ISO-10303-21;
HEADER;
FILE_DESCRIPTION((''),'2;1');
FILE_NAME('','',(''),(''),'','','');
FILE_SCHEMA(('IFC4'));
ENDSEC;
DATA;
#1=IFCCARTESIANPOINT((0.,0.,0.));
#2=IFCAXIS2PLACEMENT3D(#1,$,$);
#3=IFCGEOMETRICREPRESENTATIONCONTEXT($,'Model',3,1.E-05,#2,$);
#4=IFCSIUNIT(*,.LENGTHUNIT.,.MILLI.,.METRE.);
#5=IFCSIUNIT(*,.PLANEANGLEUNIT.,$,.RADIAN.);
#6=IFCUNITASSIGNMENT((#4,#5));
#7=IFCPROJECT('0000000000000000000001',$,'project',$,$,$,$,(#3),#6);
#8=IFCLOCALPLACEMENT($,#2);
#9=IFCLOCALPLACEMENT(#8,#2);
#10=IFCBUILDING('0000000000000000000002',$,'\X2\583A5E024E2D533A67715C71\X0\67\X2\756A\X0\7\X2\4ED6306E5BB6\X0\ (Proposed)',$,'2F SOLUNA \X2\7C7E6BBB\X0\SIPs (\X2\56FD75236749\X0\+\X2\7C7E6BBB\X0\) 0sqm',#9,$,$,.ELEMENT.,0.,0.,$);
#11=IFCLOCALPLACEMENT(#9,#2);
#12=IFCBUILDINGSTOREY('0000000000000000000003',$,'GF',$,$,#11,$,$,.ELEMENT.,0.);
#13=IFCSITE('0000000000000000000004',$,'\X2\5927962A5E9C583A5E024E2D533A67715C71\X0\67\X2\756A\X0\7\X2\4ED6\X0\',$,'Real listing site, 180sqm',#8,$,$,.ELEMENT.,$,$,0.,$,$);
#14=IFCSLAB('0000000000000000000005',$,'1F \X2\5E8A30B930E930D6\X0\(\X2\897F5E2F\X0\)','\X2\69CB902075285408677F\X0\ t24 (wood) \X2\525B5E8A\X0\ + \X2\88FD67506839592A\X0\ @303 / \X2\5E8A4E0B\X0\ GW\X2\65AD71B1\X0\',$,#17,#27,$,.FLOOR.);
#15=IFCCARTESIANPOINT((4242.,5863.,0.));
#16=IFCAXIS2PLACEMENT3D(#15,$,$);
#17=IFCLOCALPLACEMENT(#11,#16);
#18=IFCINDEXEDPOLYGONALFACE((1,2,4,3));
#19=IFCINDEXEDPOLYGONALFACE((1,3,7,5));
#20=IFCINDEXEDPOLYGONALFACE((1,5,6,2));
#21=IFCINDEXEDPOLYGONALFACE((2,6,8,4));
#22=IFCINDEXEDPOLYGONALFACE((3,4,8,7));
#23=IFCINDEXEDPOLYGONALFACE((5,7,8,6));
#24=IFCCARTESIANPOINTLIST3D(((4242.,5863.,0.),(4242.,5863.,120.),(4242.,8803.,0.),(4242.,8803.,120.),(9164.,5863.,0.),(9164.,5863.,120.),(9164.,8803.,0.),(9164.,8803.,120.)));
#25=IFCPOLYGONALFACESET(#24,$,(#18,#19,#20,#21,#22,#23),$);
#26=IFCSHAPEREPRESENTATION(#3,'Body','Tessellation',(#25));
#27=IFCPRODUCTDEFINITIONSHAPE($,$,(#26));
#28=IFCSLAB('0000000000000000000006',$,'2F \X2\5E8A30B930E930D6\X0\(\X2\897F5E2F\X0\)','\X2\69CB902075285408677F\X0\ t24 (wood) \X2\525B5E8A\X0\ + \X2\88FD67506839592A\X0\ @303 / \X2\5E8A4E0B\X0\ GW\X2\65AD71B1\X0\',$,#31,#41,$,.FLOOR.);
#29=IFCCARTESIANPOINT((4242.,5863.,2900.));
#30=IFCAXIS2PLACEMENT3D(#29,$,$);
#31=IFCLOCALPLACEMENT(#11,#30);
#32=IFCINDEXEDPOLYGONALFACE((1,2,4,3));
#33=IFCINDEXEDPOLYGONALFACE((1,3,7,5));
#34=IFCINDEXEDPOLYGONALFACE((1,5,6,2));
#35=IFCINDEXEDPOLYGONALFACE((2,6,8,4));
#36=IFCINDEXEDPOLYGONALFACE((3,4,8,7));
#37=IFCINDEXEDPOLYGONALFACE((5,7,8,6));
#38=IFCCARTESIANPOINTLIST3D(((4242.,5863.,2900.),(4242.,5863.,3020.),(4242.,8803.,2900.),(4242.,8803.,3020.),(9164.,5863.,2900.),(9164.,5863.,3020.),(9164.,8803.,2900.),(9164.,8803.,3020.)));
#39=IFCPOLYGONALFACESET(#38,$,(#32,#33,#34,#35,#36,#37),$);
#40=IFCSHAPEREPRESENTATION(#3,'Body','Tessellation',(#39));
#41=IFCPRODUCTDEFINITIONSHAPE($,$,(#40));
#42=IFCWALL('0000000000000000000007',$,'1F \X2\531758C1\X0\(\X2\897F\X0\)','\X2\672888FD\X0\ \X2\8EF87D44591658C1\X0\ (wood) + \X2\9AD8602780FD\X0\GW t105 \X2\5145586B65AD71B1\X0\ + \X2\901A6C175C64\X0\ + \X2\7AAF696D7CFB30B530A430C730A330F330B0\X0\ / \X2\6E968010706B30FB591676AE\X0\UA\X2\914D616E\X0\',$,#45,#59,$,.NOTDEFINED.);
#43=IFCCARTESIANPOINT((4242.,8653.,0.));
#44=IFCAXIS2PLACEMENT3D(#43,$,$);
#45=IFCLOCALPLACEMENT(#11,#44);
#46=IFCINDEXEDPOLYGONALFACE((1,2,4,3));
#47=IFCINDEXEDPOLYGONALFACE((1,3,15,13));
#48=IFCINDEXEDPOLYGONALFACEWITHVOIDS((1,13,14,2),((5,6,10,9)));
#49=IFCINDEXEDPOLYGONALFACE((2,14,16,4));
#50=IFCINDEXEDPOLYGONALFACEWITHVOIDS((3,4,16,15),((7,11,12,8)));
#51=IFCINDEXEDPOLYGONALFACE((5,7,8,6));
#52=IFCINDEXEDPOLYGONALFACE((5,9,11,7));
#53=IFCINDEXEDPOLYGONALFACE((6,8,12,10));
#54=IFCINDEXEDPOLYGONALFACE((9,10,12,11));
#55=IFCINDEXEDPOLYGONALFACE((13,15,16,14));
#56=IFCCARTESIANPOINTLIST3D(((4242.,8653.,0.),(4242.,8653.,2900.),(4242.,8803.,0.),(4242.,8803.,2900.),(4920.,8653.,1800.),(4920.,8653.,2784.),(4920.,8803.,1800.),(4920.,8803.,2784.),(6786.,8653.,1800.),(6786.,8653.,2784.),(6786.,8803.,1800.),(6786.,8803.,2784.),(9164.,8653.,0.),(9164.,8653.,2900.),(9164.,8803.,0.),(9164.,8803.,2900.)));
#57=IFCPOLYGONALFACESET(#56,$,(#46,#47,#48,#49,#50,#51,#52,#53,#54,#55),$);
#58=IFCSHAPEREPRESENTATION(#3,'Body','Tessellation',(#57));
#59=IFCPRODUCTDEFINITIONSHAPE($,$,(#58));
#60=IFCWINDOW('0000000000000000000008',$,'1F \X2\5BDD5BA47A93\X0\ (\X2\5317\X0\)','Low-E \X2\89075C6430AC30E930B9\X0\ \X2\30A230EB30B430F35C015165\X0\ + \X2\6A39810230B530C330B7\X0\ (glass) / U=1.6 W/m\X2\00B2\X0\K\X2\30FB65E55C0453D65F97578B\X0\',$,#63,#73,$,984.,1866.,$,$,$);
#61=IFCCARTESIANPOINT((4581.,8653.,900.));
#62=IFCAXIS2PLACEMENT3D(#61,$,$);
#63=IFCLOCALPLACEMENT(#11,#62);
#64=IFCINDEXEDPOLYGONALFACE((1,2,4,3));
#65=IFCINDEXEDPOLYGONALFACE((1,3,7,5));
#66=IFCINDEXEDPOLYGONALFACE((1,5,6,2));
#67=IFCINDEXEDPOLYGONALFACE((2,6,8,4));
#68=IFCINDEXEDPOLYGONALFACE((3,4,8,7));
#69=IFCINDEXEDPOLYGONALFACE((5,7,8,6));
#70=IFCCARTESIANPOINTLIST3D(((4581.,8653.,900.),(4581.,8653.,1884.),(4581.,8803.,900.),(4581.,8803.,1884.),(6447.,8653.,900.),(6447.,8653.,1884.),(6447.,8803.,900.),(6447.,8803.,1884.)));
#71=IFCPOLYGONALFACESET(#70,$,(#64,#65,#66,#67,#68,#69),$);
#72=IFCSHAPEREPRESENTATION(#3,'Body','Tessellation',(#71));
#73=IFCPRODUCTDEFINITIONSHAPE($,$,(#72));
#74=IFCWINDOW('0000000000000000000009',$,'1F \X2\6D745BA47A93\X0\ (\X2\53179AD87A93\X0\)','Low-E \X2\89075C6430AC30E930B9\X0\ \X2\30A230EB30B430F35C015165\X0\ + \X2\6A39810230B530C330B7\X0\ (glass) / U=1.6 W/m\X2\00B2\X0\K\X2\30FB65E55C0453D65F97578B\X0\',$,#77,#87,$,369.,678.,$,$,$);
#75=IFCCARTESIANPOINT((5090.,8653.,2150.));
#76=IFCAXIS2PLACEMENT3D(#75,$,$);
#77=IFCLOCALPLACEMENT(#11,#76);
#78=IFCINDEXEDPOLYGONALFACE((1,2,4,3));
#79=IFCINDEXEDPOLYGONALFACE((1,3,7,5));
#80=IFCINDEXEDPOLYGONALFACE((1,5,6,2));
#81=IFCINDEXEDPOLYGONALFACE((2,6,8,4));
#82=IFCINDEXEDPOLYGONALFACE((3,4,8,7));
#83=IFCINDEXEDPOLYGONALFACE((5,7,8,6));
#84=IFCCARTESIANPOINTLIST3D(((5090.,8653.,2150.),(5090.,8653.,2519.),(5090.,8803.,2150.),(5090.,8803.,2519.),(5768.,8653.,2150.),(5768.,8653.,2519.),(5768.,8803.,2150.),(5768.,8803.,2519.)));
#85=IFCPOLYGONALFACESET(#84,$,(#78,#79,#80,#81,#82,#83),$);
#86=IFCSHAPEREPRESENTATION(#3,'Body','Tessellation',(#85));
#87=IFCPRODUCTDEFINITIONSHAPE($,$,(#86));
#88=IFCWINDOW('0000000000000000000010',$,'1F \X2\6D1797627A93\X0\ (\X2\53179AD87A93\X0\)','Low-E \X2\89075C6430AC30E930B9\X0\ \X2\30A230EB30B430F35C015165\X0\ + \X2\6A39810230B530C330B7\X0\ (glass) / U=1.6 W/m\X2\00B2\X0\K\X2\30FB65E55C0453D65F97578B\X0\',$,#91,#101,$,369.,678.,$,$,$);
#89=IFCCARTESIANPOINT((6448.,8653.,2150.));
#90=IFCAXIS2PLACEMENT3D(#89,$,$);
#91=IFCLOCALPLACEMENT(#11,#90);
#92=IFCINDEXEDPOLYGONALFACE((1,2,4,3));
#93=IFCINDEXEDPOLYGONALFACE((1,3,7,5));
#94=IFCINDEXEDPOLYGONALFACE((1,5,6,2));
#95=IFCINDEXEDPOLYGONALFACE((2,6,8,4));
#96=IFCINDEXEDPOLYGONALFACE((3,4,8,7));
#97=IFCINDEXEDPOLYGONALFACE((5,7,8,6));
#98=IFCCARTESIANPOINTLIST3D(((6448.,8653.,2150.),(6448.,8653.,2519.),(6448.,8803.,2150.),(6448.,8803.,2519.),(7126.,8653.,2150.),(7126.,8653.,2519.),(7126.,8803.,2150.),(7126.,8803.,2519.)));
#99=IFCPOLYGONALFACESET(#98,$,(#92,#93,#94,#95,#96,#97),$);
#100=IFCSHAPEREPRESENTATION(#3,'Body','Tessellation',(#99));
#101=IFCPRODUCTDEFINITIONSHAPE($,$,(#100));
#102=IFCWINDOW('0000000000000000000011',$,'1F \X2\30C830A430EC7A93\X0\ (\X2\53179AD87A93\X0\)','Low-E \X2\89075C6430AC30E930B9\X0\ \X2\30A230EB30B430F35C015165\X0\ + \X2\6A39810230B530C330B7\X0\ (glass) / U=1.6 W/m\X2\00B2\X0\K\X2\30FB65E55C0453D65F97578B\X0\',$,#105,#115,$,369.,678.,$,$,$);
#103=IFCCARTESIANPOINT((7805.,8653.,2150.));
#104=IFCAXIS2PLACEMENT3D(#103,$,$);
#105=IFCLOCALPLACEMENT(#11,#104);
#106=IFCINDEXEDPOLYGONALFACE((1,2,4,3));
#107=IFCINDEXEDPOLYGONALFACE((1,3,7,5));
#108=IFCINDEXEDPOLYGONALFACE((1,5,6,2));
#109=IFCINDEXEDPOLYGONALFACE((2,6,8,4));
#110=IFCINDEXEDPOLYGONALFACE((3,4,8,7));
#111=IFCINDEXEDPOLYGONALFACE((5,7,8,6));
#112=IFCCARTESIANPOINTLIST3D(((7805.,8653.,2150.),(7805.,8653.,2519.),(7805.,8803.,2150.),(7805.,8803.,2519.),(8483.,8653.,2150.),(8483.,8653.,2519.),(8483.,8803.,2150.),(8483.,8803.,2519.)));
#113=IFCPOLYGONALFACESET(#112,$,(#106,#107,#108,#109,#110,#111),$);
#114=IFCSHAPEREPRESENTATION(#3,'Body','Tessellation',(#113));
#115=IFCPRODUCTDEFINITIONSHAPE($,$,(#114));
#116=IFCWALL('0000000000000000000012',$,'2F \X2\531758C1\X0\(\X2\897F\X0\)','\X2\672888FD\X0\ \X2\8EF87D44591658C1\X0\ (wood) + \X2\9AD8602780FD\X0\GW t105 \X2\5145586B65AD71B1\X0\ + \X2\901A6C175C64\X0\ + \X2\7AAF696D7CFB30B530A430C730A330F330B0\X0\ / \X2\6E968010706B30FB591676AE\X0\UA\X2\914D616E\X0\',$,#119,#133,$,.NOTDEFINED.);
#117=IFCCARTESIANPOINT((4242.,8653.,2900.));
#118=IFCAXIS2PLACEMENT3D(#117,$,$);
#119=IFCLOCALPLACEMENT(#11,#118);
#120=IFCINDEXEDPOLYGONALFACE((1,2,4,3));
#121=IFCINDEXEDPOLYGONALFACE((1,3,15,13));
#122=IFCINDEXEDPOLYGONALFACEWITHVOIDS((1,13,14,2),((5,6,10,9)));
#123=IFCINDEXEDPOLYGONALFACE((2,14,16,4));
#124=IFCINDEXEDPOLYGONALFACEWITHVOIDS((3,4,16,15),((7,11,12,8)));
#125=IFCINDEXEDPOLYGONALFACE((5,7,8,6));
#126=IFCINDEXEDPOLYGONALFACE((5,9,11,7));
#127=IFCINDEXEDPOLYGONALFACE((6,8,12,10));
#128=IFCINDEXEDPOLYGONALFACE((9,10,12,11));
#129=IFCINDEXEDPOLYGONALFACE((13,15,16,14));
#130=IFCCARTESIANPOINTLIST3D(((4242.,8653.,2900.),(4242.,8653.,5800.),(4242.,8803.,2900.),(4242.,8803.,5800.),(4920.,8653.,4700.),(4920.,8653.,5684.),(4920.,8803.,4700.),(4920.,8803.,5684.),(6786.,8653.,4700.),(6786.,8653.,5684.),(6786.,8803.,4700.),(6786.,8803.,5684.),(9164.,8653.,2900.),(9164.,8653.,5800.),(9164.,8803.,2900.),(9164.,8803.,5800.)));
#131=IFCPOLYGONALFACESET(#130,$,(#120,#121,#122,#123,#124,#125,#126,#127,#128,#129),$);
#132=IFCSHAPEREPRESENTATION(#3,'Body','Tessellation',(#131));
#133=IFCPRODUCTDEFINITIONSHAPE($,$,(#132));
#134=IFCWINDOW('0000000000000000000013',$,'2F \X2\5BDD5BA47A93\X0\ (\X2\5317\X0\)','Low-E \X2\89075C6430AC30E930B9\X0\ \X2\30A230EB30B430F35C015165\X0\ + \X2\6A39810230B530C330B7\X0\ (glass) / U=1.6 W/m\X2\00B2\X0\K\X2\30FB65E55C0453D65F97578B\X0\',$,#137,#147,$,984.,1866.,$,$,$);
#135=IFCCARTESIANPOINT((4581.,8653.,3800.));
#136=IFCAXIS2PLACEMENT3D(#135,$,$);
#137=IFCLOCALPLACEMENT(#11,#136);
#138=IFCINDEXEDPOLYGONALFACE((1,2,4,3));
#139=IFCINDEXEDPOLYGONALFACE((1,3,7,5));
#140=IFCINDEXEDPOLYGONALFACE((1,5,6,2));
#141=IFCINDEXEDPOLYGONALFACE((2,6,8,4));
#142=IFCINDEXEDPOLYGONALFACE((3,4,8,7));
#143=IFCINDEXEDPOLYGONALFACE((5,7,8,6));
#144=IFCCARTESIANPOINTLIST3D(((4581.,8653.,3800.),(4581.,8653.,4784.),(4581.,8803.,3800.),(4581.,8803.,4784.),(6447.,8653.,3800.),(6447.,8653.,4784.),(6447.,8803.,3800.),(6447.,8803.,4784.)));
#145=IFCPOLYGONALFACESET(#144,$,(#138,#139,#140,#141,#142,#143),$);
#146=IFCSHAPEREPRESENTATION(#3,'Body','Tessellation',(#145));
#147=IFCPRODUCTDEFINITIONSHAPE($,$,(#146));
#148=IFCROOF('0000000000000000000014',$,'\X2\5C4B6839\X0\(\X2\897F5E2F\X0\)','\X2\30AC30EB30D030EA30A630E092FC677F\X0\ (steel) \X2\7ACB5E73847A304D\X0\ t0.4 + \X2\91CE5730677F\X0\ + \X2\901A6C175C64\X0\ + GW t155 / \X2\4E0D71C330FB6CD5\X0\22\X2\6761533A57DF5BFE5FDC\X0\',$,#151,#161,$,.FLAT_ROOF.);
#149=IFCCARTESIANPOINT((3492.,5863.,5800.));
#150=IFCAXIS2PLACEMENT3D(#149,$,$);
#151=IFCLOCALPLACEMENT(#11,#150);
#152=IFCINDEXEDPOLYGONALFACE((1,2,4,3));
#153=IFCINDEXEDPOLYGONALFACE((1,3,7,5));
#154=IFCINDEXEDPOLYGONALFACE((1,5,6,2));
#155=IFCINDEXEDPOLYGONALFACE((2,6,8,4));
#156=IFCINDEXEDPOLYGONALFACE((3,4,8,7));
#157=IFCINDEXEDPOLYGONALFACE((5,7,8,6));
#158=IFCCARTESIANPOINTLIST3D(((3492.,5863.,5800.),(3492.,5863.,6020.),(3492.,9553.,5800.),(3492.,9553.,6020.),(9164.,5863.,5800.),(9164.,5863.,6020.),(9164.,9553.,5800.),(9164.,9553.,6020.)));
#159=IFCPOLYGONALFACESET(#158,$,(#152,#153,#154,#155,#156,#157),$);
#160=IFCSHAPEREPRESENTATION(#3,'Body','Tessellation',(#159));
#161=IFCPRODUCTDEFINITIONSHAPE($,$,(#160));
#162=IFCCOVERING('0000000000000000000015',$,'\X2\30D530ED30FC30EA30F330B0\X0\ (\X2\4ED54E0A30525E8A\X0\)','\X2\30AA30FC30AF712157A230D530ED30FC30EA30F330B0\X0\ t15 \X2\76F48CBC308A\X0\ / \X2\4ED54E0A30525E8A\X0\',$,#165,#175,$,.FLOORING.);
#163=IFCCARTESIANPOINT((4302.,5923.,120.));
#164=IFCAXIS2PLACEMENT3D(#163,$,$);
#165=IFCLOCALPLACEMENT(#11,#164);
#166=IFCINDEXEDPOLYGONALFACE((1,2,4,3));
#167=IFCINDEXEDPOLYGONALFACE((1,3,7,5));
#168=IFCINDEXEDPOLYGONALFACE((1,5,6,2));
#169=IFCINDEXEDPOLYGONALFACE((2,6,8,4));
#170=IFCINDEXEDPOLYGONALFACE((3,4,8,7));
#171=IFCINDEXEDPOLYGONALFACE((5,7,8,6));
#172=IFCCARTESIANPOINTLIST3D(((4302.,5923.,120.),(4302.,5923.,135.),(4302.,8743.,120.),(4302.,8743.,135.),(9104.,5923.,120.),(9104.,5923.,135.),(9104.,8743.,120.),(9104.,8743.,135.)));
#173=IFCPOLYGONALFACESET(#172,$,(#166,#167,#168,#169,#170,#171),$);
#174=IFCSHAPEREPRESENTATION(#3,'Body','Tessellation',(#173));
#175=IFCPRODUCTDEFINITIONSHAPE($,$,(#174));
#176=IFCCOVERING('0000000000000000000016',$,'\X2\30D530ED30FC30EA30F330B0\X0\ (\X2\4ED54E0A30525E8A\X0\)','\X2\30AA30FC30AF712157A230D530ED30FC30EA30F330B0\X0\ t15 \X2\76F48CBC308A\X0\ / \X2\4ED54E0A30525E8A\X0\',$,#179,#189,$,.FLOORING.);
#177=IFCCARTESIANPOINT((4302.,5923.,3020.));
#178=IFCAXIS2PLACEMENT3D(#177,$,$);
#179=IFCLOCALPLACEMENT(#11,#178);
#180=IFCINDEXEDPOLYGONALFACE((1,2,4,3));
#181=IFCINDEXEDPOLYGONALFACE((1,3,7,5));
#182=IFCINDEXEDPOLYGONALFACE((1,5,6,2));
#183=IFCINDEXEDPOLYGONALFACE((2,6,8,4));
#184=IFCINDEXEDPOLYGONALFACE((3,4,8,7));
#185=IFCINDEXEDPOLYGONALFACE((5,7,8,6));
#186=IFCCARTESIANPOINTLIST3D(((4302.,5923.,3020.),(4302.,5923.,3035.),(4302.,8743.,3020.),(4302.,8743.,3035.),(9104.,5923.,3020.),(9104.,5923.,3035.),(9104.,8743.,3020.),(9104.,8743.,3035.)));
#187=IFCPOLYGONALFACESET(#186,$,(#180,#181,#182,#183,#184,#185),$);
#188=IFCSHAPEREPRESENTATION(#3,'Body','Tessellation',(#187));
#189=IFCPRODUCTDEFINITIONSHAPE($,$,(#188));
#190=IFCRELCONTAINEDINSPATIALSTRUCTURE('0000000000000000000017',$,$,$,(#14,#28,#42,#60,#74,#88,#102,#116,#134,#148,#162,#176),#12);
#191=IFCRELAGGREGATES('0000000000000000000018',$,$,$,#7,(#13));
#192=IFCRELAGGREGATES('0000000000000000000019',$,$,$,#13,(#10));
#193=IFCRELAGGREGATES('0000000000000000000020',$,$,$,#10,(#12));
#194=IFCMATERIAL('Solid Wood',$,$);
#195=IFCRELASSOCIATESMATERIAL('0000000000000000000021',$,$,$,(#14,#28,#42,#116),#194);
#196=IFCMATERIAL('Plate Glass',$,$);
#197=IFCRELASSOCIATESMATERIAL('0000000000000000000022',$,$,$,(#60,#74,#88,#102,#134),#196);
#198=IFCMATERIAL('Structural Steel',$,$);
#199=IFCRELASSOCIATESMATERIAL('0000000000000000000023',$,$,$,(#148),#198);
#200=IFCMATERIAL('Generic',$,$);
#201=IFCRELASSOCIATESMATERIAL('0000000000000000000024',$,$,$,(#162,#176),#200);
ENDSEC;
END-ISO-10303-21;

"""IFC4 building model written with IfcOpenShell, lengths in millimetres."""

from ifc_helpers import new_model, si_unit, frame, frame_2d, origin, place, context, project, spatial, rectangle, extrude, material, element, fill, save


model = new_model("IFC4")

# Units and contexts
model_context = context("Model", 3, precision=1e-05, world=origin())
ifc_project = project(units=[si_unit("LENGTHUNIT", "METRE", prefix="MILLI"), si_unit("PLANEANGLEUNIT", "RADIAN")], contexts=[model_context])

# Site, building, storey
site_placement = place(None, origin())
site = spatial("IfcSite", under=ifc_project, at=site_placement, Name="大阪府堺市中区東山67番7他", ObjectType="Real listing site, 180sqm", CompositionType="ELEMENT", RefElevation=0.0)
building_placement = place(site_placement, origin())
building = spatial("IfcBuilding", under=site, at=building_placement, Name="堺市中区東山67番7他の家 (Proposed)", ObjectType="2F SOLUNA 籾殻SIPs (国産杉+籾殻) 0sqm", CompositionType="ELEMENT", ElevationOfRefHeight=0.0, ElevationOfTerrain=0.0)
storey_placement = place(building_placement, origin())
storey = spatial("IfcBuildingStorey", under=building, at=storey_placement, Name="GF", CompositionType="ELEMENT", Elevation=0.0)

# Slabs
ifc_material_1 = material(Name="Solid Wood")
slab_1_placement = place(storey_placement, frame((4242.0, 5863.0, 0.0)))
element("IfcSlab", 1, at=slab_1_placement, inside=storey, material=ifc_material_1, Name="1F 床スラブ(西帯)", Description="構造用合板 t24 (wood) 剛床 + 製材根太 @303 / 床下 GW断熱", PredefinedType="FLOOR", context=model_context, shape_type="SweptSolid", body=[
    extrude(rectangle(XDim=4922.0, YDim=2940.0, at=frame_2d((2461.0, 1470.0))), frame((4242.0, 5863.0, 0.0)), (0.0, 0.0, 1.0), 120.0),
])
slab_2_placement = place(storey_placement, frame((4242.0, 5863.0, 2900.0)))
element("IfcSlab", 2, at=slab_2_placement, inside=storey, material=ifc_material_1, Name="2F 床スラブ(西帯)", Description="構造用合板 t24 (wood) 剛床 + 製材根太 @303 / 床下 GW断熱", PredefinedType="FLOOR", context=model_context, shape_type="SweptSolid", body=[
    extrude(rectangle(XDim=4922.0, YDim=2940.0, at=frame_2d((2461.0, 1470.0))), frame((4242.0, 5863.0, 2900.0)), (0.0, 0.0, 1.0), 120.0),
])

# Wall, openings, windows
wall_1_placement = place(storey_placement, frame((4242.0, 8653.0, 0.0)))
wall_1 = element("IfcWall", 3, at=wall_1_placement, inside=storey, material=ifc_material_1, Name="1F 北壁(西)", Description="木製 軸組外壁 (wood) + 高性能GW t105 充填断熱 + 通気層 + 窯業系サイディング / 準耐火・外皮UA配慮", PredefinedType="NOTDEFINED", context=model_context, shape_type="SweptSolid", body=[
    extrude(rectangle(XDim=4922.0, YDim=150.0, at=frame_2d((2461.0, 75.0))), frame((4242.0, 8653.0, 0.0)), (0.0, 0.0, 1.0), 2900.0),
])
opening_1_placement = place(storey_placement, frame((4581.0, 8653.0, 900.0)))
opening_1 = element("IfcOpeningElement", 4, at=opening_1_placement, cuts=wall_1, PredefinedType="NOTDEFINED", context=model_context, shape_type="SweptSolid", body=[
    extrude(rectangle(XDim=1866.0, YDim=150.0, at=frame_2d((933.0, 75.0))), frame((4581.0, 8653.0, 900.0)), (0.0, 0.0, 1.0), 984.0),
])
opening_2_placement = place(storey_placement, frame((5090.0, 8653.0, 2150.0)))
opening_2 = element("IfcOpeningElement", 5, at=opening_2_placement, cuts=wall_1, PredefinedType="NOTDEFINED", context=model_context, shape_type="SweptSolid", body=[
    extrude(rectangle(XDim=678.0, YDim=150.0, at=frame_2d((339.0, 75.0))), frame((5090.0, 8653.0, 2150.0)), (0.0, 0.0, 1.0), 369.0),
])
opening_3_placement = place(storey_placement, frame((6448.0, 8653.0, 2150.0)))
opening_3 = element("IfcOpeningElement", 6, at=opening_3_placement, cuts=wall_1, PredefinedType="NOTDEFINED", context=model_context, shape_type="SweptSolid", body=[
    extrude(rectangle(XDim=678.0, YDim=150.0, at=frame_2d((339.0, 75.0))), frame((6448.0, 8653.0, 2150.0)), (0.0, 0.0, 1.0), 369.0),
])
opening_4_placement = place(storey_placement, frame((7805.0, 8653.0, 2150.0)))
opening_4 = element("IfcOpeningElement", 7, at=opening_4_placement, cuts=wall_1, PredefinedType="NOTDEFINED", context=model_context, shape_type="SweptSolid", body=[
    extrude(rectangle(XDim=678.0, YDim=150.0, at=frame_2d((339.0, 75.0))), frame((7805.0, 8653.0, 2150.0)), (0.0, 0.0, 1.0), 369.0),
])
ifc_material_2 = material(Name="Plate Glass")
window_1_placement = place(storey_placement, frame((4581.0, 8653.0, 900.0)))
window_1 = element("IfcWindow", 8, at=window_1_placement, inside=storey, material=ifc_material_2, Name="1F 寝室窓 (北)", Description="Low-E 複層ガラス アルゴン封入 + 樹脂サッシ (glass) / U=1.6 W/m²K・日射取得型", OverallHeight=984.0, OverallWidth=1866.0, context=model_context, shape_type="SweptSolid", body=[
    extrude(rectangle(XDim=1866.0, YDim=150.0, at=frame_2d((933.0, 75.0))), frame((4581.0, 8653.0, 900.0)), (0.0, 0.0, 1.0), 984.0),
])
fill(opening_1, window_1)
window_2_placement = place(storey_placement, frame((5090.0, 8653.0, 2150.0)))
window_2 = element("IfcWindow", 9, at=window_2_placement, inside=storey, material=ifc_material_2, Name="1F 浴室窓 (北高窓)", Description="Low-E 複層ガラス アルゴン封入 + 樹脂サッシ (glass) / U=1.6 W/m²K・日射取得型", OverallHeight=369.0, OverallWidth=678.0, context=model_context, shape_type="SweptSolid", body=[
    extrude(rectangle(XDim=678.0, YDim=150.0, at=frame_2d((339.0, 75.0))), frame((5090.0, 8653.0, 2150.0)), (0.0, 0.0, 1.0), 369.0),
])
fill(opening_2, window_2)
window_3_placement = place(storey_placement, frame((6448.0, 8653.0, 2150.0)))
window_3 = element("IfcWindow", 10, at=window_3_placement, inside=storey, material=ifc_material_2, Name="1F 洗面窓 (北高窓)", Description="Low-E 複層ガラス アルゴン封入 + 樹脂サッシ (glass) / U=1.6 W/m²K・日射取得型", OverallHeight=369.0, OverallWidth=678.0, context=model_context, shape_type="SweptSolid", body=[
    extrude(rectangle(XDim=678.0, YDim=150.0, at=frame_2d((339.0, 75.0))), frame((6448.0, 8653.0, 2150.0)), (0.0, 0.0, 1.0), 369.0),
])
fill(opening_3, window_3)
window_4_placement = place(storey_placement, frame((7805.0, 8653.0, 2150.0)))
window_4 = element("IfcWindow", 11, at=window_4_placement, inside=storey, material=ifc_material_2, Name="1F トイレ窓 (北高窓)", Description="Low-E 複層ガラス アルゴン封入 + 樹脂サッシ (glass) / U=1.6 W/m²K・日射取得型", OverallHeight=369.0, OverallWidth=678.0, context=model_context, shape_type="SweptSolid", body=[
    extrude(rectangle(XDim=678.0, YDim=150.0, at=frame_2d((339.0, 75.0))), frame((7805.0, 8653.0, 2150.0)), (0.0, 0.0, 1.0), 369.0),
])
fill(opening_4, window_4)

# Wall, opening, window
wall_2_placement = place(storey_placement, frame((4242.0, 8653.0, 2900.0)))
wall_2 = element("IfcWall", 12, at=wall_2_placement, inside=storey, material=ifc_material_1, Name="2F 北壁(西)", Description="木製 軸組外壁 (wood) + 高性能GW t105 充填断熱 + 通気層 + 窯業系サイディング / 準耐火・外皮UA配慮", PredefinedType="NOTDEFINED", context=model_context, shape_type="SweptSolid", body=[
    extrude(rectangle(XDim=4922.0, YDim=150.0, at=frame_2d((2461.0, 75.0))), frame((4242.0, 8653.0, 2900.0)), (0.0, 0.0, 1.0), 2900.0),
])
opening_5_placement = place(storey_placement, frame((4581.0, 8653.0, 3800.0)))
opening_5 = element("IfcOpeningElement", 13, at=opening_5_placement, cuts=wall_2, PredefinedType="NOTDEFINED", context=model_context, shape_type="SweptSolid", body=[
    extrude(rectangle(XDim=1866.0, YDim=150.0, at=frame_2d((933.0, 75.0))), frame((4581.0, 8653.0, 3800.0)), (0.0, 0.0, 1.0), 984.0),
])
window_5_placement = place(storey_placement, frame((4581.0, 8653.0, 3800.0)))
window_5 = element("IfcWindow", 14, at=window_5_placement, inside=storey, material=ifc_material_2, Name="2F 寝室窓 (北)", Description="Low-E 複層ガラス アルゴン封入 + 樹脂サッシ (glass) / U=1.6 W/m²K・日射取得型", OverallHeight=984.0, OverallWidth=1866.0, context=model_context, shape_type="SweptSolid", body=[
    extrude(rectangle(XDim=1866.0, YDim=150.0, at=frame_2d((933.0, 75.0))), frame((4581.0, 8653.0, 3800.0)), (0.0, 0.0, 1.0), 984.0),
])
fill(opening_5, window_5)

# Roof
ifc_material_3 = material(Name="Structural Steel")
for number, where, name in (
    (15, (3492.0, 5863.0, 5800.0), "屋根(西帯)"),
):
    element("IfcRoof", number, at=place(storey_placement, frame(where)), inside=storey, material=ifc_material_3, Name=name, Description="ガルバリウム鋼板 (steel) 立平葺き t0.4 + 野地板 + 通気層 + GW t155 / 不燃・法22条区域対応", PredefinedType="FLAT_ROOF", context=model_context, shape_type="SweptSolid", body=[
        extrude(rectangle(XDim=5672.0, YDim=3690.0, at=frame_2d((2836.0, 1845.0))), frame((3492.0, 5863.0, 5800.0)), (0.0, 0.0, 1.0), 220.0),
    ])

# Coverings
ifc_material_4 = material(Name="Generic")
covering_1_placement = place(storey_placement, frame((4302.0, 5923.0, 120.0)))
element("IfcCovering", 16, at=covering_1_placement, inside=storey, material=ifc_material_4, Name="フローリング (仕上げ床)", Description="オーク無垢フローリング t15 直貼り / 仕上げ床", PredefinedType="FLOORING", context=model_context, shape_type="SweptSolid", body=[
    extrude(rectangle(XDim=4802.0, YDim=2820.0, at=frame_2d((2401.0, 1410.0))), frame((4302.0, 5923.0, 120.0)), (0.0, 0.0, 1.0), 15.0),
])
covering_2_placement = place(storey_placement, frame((4302.0, 5923.0, 3020.0)))
element("IfcCovering", 17, at=covering_2_placement, inside=storey, material=ifc_material_4, Name="フローリング (仕上げ床)", Description="オーク無垢フローリング t15 直貼り / 仕上げ床", PredefinedType="FLOORING", context=model_context, shape_type="SweptSolid", body=[
    extrude(rectangle(XDim=4802.0, YDim=2820.0, at=frame_2d((2401.0, 1410.0))), frame((4302.0, 5923.0, 3020.0)), (0.0, 0.0, 1.0), 15.0),
])

save(model, "model.ifc")
